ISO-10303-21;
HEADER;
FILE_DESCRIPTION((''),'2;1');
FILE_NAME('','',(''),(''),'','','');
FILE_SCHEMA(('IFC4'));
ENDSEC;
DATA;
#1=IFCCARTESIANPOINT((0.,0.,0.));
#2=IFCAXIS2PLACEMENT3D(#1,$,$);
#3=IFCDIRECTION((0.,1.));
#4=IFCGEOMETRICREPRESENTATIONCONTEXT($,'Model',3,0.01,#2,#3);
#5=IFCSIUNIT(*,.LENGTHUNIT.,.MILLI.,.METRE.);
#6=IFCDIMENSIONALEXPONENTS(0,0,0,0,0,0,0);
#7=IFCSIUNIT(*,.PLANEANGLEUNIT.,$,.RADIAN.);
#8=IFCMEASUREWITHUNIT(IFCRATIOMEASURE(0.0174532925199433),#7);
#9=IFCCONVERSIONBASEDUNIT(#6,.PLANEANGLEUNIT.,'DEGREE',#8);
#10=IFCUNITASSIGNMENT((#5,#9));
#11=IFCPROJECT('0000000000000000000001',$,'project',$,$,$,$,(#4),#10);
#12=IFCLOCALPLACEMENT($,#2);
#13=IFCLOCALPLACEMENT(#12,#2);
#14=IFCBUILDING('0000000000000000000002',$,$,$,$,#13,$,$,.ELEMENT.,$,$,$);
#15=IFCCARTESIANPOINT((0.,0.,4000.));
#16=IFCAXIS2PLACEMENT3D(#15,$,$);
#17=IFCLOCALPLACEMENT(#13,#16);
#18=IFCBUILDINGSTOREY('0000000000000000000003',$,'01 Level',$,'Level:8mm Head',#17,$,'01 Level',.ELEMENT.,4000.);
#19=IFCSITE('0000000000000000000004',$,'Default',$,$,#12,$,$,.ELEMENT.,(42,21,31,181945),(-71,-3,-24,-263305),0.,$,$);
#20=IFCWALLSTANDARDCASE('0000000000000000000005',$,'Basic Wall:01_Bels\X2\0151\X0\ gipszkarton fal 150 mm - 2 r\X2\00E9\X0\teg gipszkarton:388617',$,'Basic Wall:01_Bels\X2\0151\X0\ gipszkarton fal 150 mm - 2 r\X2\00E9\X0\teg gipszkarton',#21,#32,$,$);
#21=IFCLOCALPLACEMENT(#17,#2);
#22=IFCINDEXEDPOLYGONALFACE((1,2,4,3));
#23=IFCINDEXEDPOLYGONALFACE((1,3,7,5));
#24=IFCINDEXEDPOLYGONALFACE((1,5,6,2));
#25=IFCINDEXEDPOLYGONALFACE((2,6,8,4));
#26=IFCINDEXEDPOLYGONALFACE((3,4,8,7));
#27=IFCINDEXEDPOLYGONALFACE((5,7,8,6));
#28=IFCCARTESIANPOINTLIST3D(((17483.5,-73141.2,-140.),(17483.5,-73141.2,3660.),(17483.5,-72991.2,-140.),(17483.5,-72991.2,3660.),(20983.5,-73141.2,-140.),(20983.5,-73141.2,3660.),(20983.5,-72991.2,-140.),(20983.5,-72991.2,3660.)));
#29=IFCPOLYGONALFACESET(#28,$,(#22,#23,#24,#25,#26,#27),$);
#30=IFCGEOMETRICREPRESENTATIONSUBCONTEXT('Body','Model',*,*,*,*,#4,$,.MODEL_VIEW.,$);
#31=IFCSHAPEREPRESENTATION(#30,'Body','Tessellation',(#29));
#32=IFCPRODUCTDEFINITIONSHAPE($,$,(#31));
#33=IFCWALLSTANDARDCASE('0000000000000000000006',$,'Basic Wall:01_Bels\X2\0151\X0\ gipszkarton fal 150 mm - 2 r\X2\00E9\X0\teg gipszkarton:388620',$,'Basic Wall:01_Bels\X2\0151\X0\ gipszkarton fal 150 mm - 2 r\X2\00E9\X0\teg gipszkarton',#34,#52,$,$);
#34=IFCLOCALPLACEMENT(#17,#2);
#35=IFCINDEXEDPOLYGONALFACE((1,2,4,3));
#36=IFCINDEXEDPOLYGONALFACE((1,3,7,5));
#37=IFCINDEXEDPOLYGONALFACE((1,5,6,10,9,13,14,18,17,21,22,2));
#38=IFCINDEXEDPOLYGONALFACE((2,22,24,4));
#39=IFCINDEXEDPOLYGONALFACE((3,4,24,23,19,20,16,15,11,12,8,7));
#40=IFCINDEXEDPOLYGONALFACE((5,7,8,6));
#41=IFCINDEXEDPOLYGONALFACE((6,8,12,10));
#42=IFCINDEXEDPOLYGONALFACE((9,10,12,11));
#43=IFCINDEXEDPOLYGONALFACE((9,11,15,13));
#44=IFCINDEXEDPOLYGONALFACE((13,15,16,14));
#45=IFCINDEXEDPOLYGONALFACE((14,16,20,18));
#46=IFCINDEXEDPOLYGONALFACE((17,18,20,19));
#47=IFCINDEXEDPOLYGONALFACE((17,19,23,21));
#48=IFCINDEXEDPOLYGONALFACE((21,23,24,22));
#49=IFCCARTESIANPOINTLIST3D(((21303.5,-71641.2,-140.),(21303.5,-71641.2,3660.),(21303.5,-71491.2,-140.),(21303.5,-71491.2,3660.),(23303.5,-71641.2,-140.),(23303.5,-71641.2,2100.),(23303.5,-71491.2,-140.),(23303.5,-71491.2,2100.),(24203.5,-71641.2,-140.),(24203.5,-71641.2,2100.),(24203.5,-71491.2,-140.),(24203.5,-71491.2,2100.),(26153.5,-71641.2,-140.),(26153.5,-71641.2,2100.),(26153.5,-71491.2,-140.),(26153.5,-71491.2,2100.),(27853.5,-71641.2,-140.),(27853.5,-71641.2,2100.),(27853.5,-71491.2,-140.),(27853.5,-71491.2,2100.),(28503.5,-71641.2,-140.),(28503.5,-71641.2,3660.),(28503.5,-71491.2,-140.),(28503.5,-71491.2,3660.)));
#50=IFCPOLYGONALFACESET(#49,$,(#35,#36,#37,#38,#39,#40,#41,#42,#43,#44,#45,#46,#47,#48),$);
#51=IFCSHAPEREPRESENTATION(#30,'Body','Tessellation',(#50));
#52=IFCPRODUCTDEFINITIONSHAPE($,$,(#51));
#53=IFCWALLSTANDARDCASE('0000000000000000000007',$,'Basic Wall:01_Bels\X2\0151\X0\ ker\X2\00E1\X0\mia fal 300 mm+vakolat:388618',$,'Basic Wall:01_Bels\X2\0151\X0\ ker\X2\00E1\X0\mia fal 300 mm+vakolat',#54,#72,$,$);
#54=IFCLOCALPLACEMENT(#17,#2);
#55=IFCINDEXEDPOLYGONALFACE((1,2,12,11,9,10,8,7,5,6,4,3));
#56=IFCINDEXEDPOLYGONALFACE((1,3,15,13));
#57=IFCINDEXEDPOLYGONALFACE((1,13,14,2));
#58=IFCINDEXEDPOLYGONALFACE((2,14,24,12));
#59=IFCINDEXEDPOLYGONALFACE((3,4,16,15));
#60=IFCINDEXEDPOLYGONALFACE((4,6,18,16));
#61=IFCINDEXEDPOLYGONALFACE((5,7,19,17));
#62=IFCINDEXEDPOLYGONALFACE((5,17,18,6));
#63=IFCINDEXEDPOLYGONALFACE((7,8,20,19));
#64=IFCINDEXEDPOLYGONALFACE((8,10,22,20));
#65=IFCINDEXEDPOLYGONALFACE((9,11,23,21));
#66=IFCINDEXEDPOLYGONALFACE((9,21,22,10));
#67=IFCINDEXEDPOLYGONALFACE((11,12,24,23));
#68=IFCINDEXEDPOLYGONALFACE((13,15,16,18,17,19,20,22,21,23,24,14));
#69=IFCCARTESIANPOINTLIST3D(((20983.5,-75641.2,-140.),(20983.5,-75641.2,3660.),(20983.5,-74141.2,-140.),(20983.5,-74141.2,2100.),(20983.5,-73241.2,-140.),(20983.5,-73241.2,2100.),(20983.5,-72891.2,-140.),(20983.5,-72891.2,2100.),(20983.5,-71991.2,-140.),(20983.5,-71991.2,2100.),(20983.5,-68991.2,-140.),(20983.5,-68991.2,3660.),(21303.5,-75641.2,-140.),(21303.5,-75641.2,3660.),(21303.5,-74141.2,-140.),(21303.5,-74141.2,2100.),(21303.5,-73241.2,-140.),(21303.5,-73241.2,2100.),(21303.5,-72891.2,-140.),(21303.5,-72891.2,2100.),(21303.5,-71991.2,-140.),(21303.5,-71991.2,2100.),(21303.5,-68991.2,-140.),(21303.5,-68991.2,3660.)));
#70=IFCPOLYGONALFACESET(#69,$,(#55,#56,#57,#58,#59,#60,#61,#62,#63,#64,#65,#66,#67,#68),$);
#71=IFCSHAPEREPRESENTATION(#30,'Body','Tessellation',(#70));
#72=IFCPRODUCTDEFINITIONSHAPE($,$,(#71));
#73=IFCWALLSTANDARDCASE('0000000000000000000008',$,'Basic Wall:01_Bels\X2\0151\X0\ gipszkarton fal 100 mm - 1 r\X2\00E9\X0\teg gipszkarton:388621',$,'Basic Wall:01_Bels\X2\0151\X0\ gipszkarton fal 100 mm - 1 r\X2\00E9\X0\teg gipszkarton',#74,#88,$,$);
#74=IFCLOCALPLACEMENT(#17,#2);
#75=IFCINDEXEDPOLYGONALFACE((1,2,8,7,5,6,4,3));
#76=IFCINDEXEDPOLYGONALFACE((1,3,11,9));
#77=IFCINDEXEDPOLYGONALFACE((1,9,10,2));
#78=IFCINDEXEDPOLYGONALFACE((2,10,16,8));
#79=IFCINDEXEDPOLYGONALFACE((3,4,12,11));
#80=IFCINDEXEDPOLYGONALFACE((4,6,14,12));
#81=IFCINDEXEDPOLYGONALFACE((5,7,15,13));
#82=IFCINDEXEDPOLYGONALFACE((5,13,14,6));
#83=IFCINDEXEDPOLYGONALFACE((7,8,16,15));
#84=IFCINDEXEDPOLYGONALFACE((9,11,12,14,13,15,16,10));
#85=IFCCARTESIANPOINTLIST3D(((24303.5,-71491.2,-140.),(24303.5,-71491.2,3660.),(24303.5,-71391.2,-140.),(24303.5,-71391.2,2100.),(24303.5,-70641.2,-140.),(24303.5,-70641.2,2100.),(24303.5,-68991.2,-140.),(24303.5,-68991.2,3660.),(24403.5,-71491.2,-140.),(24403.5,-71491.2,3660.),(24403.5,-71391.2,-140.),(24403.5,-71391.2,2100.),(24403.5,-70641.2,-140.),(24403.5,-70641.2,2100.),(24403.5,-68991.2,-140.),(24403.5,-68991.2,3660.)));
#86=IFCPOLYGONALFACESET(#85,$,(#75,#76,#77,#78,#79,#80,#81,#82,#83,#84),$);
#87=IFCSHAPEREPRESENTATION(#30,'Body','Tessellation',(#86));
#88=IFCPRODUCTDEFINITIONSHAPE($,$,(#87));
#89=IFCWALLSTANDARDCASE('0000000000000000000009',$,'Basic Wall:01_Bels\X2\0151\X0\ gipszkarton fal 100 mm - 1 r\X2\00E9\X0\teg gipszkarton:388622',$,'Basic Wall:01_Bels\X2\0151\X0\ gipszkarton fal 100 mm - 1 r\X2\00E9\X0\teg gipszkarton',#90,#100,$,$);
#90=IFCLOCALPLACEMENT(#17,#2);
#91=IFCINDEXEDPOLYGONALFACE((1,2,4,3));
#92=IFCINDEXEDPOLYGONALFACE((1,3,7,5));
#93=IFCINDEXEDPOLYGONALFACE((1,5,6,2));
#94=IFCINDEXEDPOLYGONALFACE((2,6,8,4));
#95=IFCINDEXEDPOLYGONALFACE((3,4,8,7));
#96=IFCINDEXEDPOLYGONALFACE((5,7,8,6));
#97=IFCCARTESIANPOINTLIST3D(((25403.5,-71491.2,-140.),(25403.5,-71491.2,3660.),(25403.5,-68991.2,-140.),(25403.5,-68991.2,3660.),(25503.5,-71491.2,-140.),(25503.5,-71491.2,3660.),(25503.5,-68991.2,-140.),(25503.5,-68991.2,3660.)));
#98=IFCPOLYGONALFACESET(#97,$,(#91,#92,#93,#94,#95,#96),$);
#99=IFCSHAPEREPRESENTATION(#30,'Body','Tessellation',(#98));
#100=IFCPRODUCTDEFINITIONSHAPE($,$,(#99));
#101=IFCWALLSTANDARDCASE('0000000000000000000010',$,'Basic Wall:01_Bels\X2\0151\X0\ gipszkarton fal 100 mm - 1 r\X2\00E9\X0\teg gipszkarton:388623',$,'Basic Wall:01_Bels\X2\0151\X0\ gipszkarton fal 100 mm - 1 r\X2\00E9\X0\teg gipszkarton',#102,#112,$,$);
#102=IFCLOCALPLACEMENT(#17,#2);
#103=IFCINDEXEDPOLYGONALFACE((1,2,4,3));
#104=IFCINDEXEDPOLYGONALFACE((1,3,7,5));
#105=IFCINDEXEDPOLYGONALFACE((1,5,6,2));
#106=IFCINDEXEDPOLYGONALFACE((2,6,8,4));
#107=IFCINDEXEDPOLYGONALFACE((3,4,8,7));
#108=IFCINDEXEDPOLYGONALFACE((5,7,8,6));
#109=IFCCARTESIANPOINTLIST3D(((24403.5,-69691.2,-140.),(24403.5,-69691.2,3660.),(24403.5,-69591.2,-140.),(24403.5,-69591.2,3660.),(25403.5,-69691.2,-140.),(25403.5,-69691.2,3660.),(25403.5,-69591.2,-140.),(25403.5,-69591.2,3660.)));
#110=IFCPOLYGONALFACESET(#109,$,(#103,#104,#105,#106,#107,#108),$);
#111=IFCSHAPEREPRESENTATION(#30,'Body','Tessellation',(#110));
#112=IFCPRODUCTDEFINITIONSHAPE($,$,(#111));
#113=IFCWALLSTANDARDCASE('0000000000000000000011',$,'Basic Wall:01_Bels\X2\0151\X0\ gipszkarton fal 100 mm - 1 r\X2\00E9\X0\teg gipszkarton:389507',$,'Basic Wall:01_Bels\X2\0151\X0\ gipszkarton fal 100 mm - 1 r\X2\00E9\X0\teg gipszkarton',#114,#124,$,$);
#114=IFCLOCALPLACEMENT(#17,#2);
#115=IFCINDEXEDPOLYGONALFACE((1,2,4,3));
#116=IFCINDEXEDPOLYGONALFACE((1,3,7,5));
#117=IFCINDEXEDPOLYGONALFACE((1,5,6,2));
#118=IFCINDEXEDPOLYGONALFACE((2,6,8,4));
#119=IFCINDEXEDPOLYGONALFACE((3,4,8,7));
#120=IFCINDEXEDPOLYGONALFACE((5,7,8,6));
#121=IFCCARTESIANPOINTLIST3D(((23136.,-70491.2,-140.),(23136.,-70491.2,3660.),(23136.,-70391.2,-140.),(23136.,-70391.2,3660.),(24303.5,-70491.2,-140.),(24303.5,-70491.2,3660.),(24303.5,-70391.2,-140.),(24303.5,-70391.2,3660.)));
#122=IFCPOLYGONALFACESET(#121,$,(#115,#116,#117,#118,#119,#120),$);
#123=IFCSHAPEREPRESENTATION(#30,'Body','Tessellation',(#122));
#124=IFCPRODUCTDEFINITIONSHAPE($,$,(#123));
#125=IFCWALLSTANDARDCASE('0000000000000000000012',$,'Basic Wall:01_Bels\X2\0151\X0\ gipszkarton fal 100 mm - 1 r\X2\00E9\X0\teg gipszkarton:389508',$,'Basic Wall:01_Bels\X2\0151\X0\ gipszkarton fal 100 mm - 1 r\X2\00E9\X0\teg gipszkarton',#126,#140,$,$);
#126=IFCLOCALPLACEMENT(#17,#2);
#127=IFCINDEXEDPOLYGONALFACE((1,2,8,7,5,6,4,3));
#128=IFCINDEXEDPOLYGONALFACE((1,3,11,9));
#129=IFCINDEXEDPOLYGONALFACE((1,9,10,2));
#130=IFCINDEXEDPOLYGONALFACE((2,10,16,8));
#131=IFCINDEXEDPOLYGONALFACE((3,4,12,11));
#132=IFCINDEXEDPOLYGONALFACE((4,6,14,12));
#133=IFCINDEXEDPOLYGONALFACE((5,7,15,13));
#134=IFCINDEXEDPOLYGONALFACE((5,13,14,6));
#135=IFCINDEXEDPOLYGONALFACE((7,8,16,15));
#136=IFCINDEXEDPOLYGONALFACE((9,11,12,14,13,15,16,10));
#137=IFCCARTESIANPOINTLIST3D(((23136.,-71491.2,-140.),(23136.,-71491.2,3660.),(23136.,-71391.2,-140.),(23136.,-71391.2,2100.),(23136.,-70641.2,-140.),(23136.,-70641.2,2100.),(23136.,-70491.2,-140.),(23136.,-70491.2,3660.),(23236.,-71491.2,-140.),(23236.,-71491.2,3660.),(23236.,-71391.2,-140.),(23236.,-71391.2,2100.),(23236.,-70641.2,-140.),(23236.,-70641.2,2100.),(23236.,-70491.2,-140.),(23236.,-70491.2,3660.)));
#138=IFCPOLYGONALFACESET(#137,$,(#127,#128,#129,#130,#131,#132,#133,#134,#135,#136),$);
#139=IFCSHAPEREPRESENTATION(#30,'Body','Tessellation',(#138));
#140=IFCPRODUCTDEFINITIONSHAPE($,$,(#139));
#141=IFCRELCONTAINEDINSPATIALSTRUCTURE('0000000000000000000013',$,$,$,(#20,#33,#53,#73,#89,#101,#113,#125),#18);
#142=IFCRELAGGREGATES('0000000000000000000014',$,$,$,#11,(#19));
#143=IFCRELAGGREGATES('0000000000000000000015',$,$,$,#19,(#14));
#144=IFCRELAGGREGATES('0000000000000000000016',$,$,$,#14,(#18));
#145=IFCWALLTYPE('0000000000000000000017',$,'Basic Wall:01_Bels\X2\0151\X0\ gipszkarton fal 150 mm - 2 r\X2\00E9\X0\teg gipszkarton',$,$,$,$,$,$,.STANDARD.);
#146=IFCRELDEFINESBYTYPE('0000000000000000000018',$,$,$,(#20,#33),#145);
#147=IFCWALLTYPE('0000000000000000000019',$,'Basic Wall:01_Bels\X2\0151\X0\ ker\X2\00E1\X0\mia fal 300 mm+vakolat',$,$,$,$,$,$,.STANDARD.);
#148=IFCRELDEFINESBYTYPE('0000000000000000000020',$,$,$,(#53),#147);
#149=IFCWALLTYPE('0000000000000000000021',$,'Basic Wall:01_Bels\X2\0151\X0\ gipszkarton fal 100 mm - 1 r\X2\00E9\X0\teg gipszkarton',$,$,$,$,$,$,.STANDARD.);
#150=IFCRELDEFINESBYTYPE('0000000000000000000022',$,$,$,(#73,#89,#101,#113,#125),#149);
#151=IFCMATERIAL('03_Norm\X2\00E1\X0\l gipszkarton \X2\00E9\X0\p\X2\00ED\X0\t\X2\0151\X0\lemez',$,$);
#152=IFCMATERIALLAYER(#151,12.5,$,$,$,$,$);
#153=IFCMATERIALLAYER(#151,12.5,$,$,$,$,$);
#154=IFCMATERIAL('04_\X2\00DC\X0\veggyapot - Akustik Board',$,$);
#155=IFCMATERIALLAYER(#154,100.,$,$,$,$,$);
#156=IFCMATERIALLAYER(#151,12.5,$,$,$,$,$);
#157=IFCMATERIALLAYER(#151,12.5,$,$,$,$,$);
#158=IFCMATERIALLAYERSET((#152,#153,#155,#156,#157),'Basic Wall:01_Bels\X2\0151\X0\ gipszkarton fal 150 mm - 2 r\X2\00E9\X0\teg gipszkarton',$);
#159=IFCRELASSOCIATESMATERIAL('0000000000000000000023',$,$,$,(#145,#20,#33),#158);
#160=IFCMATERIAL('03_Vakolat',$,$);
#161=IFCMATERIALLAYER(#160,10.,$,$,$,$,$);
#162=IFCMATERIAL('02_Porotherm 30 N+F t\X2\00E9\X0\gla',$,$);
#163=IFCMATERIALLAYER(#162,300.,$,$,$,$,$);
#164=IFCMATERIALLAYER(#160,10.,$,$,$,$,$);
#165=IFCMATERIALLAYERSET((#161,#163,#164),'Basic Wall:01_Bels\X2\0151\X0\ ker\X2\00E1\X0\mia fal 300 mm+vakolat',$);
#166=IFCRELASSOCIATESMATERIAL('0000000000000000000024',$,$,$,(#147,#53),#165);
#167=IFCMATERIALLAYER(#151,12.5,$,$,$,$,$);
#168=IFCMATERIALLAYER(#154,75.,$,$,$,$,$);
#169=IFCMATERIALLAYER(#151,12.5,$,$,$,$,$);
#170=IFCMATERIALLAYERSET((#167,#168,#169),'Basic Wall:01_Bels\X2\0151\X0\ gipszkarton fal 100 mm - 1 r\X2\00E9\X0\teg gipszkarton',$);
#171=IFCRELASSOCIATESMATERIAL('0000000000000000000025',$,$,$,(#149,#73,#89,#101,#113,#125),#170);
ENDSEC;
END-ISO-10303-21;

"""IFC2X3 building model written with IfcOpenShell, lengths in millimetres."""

from ifc_helpers import new_model, entity, si_unit, converted_unit, direction, frame, frame_2d, origin, origin_2d_with_axis, place, context, subcontext, project, spatial, rectangle, extrude, material, layer, layer_set, layer_usage, type_object, element, save


model = new_model("IFC2X3")

# Units and contexts
model_context = context("Model", 3, precision=0.01, world=origin(), true_north=direction((0.0, 1.0)))
body_context = subcontext(model_context, "Body", "Model", "MODEL_VIEW")
ifc_project = project(units=[si_unit("LENGTHUNIT", "METRE", prefix="MILLI"), converted_unit("PLANEANGLEUNIT", "DEGREE", entity("IfcRatioMeasure", 0.0174532925199433), si_unit("PLANEANGLEUNIT", "RADIAN"), dimensions=[0, 0, 0, 0, 0, 0, 0])], contexts=[model_context])

# Site, building, storey
site_placement = place(None, origin())
site = spatial("IfcSite", under=ifc_project, at=site_placement, Name="Default", CompositionType="ELEMENT", RefLatitude=(42, 21, 31, 181945), RefLongitude=(-71, -3, -24, -263305), RefElevation=0.0)
building_placement = place(site_placement, origin())
building = spatial("IfcBuilding", under=site, at=building_placement, CompositionType="ELEMENT")
storey_placement = place(building_placement, frame((0.0, 0.0, 4000.0)))
storey = spatial("IfcBuildingStorey", under=building, at=storey_placement, Name="01 Level", ObjectType="Level:8mm Head", LongName="01 Level", CompositionType="ELEMENT", Elevation=4000.0)

# Wall
ifc_material_1 = material(Name="03_Normál gipszkarton építőlemez")
ifc_layer_1 = layer(ifc_material_1, 12.5)
ifc_layer_2 = layer(ifc_material_1, 12.5)
ifc_material_2 = material(Name="04_Üveggyapot - Akustik Board")
ifc_layer_3 = layer(ifc_material_2, 100.0)
ifc_layer_4 = layer(ifc_material_1, 12.5)
ifc_layer_5 = layer(ifc_material_1, 12.5)
ifc_layer_set_1 = layer_set([ifc_layer_1, ifc_layer_2, ifc_layer_3, ifc_layer_4, ifc_layer_5], Name="Basic Wall:01_Belső gipszkarton fal 150 mm - 2 réteg gipszkarton")
ifc_layer_usage_1 = layer_usage(ifc_layer_set_1, "AXIS2", "NEGATIVE", 75.0)
wall_type_1 = type_object("IfcWallType", Name="Basic Wall:01_Belső gipszkarton fal 150 mm - 2 réteg gipszkarton", PredefinedType="STANDARD", material=ifc_layer_set_1)
wall_1_placement = place(storey_placement, frame((17483.5, -73066.2, -140.0)))
element("IfcWallStandardCase", 1, at=wall_1_placement, inside=storey, type_object=wall_type_1, material=ifc_layer_usage_1, Name="Basic Wall:01_Belső gipszkarton fal 150 mm - 2 réteg gipszkarton:388617", ObjectType="Basic Wall:01_Belső gipszkarton fal 150 mm - 2 réteg gipszkarton", context=body_context, shape_type="SweptSolid", body=[
    extrude(rectangle(XDim=3500.0, YDim=150.0, at=frame_2d((1750.0, 0.0), x_axis=(-1.0, 0.0))), origin(), (0.0, 0.0, 1.0), 3800.0),
])

# Walls, openings
ifc_layer_usage_2 = layer_usage(ifc_layer_set_1, "AXIS2", "NEGATIVE", 75.0)
wall_2_placement = place(storey_placement, frame((21303.5, -71566.2, -140.0)))
wall_2 = element("IfcWallStandardCase", 2, at=wall_2_placement, inside=storey, type_object=wall_type_1, material=ifc_layer_usage_2, Name="Basic Wall:01_Belső gipszkarton fal 150 mm - 2 réteg gipszkarton:388620", ObjectType="Basic Wall:01_Belső gipszkarton fal 150 mm - 2 réteg gipszkarton", context=body_context, shape_type="SweptSolid", body=[
    extrude(rectangle(XDim=7200.0, YDim=150.0, at=frame_2d((3600.0, 0.0), x_axis=(-1.0, 0.0))), origin(), (0.0, 0.0, 1.0), 3800.0),
])
opening_1_placement = place(wall_2_placement, frame((4850.0, -75.0, 0.0)))
element("IfcOpeningElement", 3, at=opening_1_placement, cuts=wall_2, ObjectType="Opening", context=body_context, shape_type="SweptSolid", body=[
    extrude(rectangle(XDim=2240.0, YDim=1700.0, at=frame_2d((0.0, 0.0), x_axis=(1.0, 0.0))), frame((850.0, 0.0, 1120.0), z_axis=(0.0, 1.0, 0.0), x_axis=(0.0, 0.0, -1.0)), (0.0, 0.0, 1.0), 150.0),
])
opening_2_placement = place(wall_2_placement, frame((2000.0, -1449.0, 0.0)))
element("IfcOpeningElement", 4, at=opening_2_placement, cuts=wall_2, ObjectType="Opening", context=body_context, shape_type="SweptSolid", body=[
    extrude(rectangle(XDim=2240.0, YDim=900.0, at=frame_2d((0.0, 0.0), x_axis=(0.0, 1.0))), frame((450.0, 0.0, 1120.0), z_axis=(0.0, 1.0, 0.0), x_axis=(-1.0, 0.0, 0.0)), (0.0, 0.0, 1.0), 3048.0),
])
ifc_material_3 = material(Name="03_Vakolat")
ifc_layer_6 = layer(ifc_material_3, 10.0)
ifc_material_4 = material(Name="02_Porotherm 30 N+F tégla")
ifc_layer_7 = layer(ifc_material_4, 300.0)
ifc_layer_8 = layer(ifc_material_3, 10.0)
ifc_layer_set_2 = layer_set([ifc_layer_6, ifc_layer_7, ifc_layer_8], Name="Basic Wall:01_Belső kerámia fal 300 mm+vakolat")
ifc_layer_usage_3 = layer_usage(ifc_layer_set_2, "AXIS2", "NEGATIVE", 160.0)
wall_type_2 = type_object("IfcWallType", Name="Basic Wall:01_Belső kerámia fal 300 mm+vakolat", PredefinedType="STANDARD", material=ifc_layer_set_2)
wall_3_placement = place(storey_placement, frame((21143.5, -68991.2, -140.0), z_axis=(0.0, 0.0, 1.0), x_axis=(0.0, -1.0, 0.0)))
wall_3 = element("IfcWallStandardCase", 5, at=wall_3_placement, inside=storey, type_object=wall_type_2, material=ifc_layer_usage_3, Name="Basic Wall:01_Belső kerámia fal 300 mm+vakolat:388618", ObjectType="Basic Wall:01_Belső kerámia fal 300 mm+vakolat", context=body_context, shape_type="SweptSolid", body=[
    extrude(rectangle(XDim=6650.0, YDim=320.0, at=frame_2d((3325.0, 0.0), x_axis=(-1.0, 0.0))), origin(), (0.0, 0.0, 1.0), 3800.0),
])
opening_3_placement = place(wall_3_placement, frame((3900.0, -1364.0, 0.0), z_axis=(0.0, 0.0, 1.0), x_axis=(0.0, 1.0, 0.0)))
element("IfcOpeningElement", 6, at=opening_3_placement, cuts=wall_3, ObjectType="Opening", context=body_context, shape_type="SweptSolid", body=[
    extrude(rectangle(XDim=2240.0, YDim=900.0, at=origin_2d_with_axis()), frame((0.0, 450.0, 1120.0), z_axis=(1.0, 0.0, 0.0), x_axis=(0.0, 0.0, 1.0)), (0.0, 0.0, 1.0), 3048.0),
])
opening_4_placement = place(wall_3_placement, frame((5150.0, -1364.0, 0.0), z_axis=(0.0, 0.0, 1.0), x_axis=(0.0, 1.0, 0.0)))
element("IfcOpeningElement", 7, at=opening_4_placement, cuts=wall_3, ObjectType="Opening", context=body_context, shape_type="SweptSolid", body=[
    extrude(rectangle(XDim=2240.0, YDim=900.0, at=frame_2d((0.0, 0.0), x_axis=(0.0, 1.0))), frame((0.0, 450.0, 1120.0), z_axis=(1.0, 0.0, 0.0), x_axis=(0.0, 1.0, 0.0)), (0.0, 0.0, 1.0), 3048.0),
])

# Wall, opening
ifc_layer_9 = layer(ifc_material_1, 12.5)
ifc_layer_10 = layer(ifc_material_2, 75.0)
ifc_layer_11 = layer(ifc_material_1, 12.5)
ifc_layer_set_3 = layer_set([ifc_layer_9, ifc_layer_10, ifc_layer_11], Name="Basic Wall:01_Belső gipszkarton fal 100 mm - 1 réteg gipszkarton")
ifc_layer_usage_4 = layer_usage(ifc_layer_set_3, "AXIS2", "NEGATIVE", 50.0)
wall_type_3 = type_object("IfcWallType", Name="Basic Wall:01_Belső gipszkarton fal 100 mm - 1 réteg gipszkarton", PredefinedType="STANDARD", material=ifc_layer_set_3)
wall_4_placement = place(storey_placement, frame((24353.5, -71491.2, -140.0), z_axis=(0.0, 0.0, 1.0), x_axis=(0.0, 1.0, 0.0)))
wall_4 = element("IfcWallStandardCase", 8, at=wall_4_placement, inside=storey, type_object=wall_type_3, material=ifc_layer_usage_4, Name="Basic Wall:01_Belső gipszkarton fal 100 mm - 1 réteg gipszkarton:388621", ObjectType="Basic Wall:01_Belső gipszkarton fal 100 mm - 1 réteg gipszkarton", context=body_context, shape_type="SweptSolid", body=[
    extrude(rectangle(XDim=2500.0, YDim=100.0, at=frame_2d((1250.0, 0.0), x_axis=(-1.0, 0.0))), origin(), (0.0, 0.0, 1.0), 3800.0),
])
opening_5_placement = place(wall_4_placement, frame((100.0, 1574.0, 0.0), z_axis=(0.0, 0.0, 1.0), x_axis=(0.0, -1.0, 0.0)))
element("IfcOpeningElement", 9, at=opening_5_placement, cuts=wall_4, ObjectType="Opening", context=body_context, shape_type="SweptSolid", body=[
    extrude(rectangle(XDim=2240.0, YDim=750.0, at=frame_2d((0.0, 0.0), x_axis=(0.0, 1.0))), frame((3048.0, 375.0, 1120.0), z_axis=(-1.0, 0.0, 0.0), x_axis=(0.0, -1.0, 0.0)), (0.0, 0.0, 1.0), 3048.0),
])

# Walls
ifc_layer_usage_5 = layer_usage(ifc_layer_set_3, "AXIS2", "NEGATIVE", 50.0)
wall_5_placement = place(storey_placement, frame((25453.5, -71491.2, -140.0), z_axis=(0.0, 0.0, 1.0), x_axis=(0.0, 1.0, 0.0)))
element("IfcWallStandardCase", 10, at=wall_5_placement, inside=storey, type_object=wall_type_3, material=ifc_layer_usage_5, Name="Basic Wall:01_Belső gipszkarton fal 100 mm - 1 réteg gipszkarton:388622", ObjectType="Basic Wall:01_Belső gipszkarton fal 100 mm - 1 réteg gipszkarton", context=body_context, shape_type="SweptSolid", body=[
    extrude(rectangle(XDim=2500.0, YDim=100.0, at=frame_2d((1250.0, 0.0), x_axis=(-1.0, 0.0))), origin(), (0.0, 0.0, 1.0), 3800.0),
])
ifc_layer_usage_6 = layer_usage(ifc_layer_set_3, "AXIS2", "NEGATIVE", 50.0)
wall_6_placement = place(storey_placement, frame((24403.5, -69641.2, -140.0)))
element("IfcWallStandardCase", 11, at=wall_6_placement, inside=storey, type_object=wall_type_3, material=ifc_layer_usage_6, Name="Basic Wall:01_Belső gipszkarton fal 100 mm - 1 réteg gipszkarton:388623", ObjectType="Basic Wall:01_Belső gipszkarton fal 100 mm - 1 réteg gipszkarton", context=body_context, shape_type="SweptSolid", body=[
    extrude(rectangle(XDim=1000.0, YDim=100.0, at=frame_2d((500.0, 0.0), x_axis=(-1.0, 0.0))), origin(), (0.0, 0.0, 1.0), 3800.0),
])
ifc_layer_usage_7 = layer_usage(ifc_layer_set_3, "AXIS2", "NEGATIVE", 50.0)
wall_7_placement = place(storey_placement, frame((24303.5, -70441.2, -140.0), z_axis=(0.0, 0.0, 1.0), x_axis=(-1.0, 0.0, 0.0)))
element("IfcWallStandardCase", 12, at=wall_7_placement, inside=storey, type_object=wall_type_3, material=ifc_layer_usage_7, Name="Basic Wall:01_Belső gipszkarton fal 100 mm - 1 réteg gipszkarton:389507", ObjectType="Basic Wall:01_Belső gipszkarton fal 100 mm - 1 réteg gipszkarton", context=body_context, shape_type="SweptSolid", body=[
    extrude(rectangle(XDim=1167.5, YDim=100.0, at=frame_2d((583.7, 0.0), x_axis=(-1.0, 0.0))), origin(), (0.0, 0.0, 1.0), 3800.0),
])

# Wall, opening
ifc_layer_usage_8 = layer_usage(ifc_layer_set_3, "AXIS2", "NEGATIVE", 50.0)
wall_8_placement = place(storey_placement, frame((23186.0, -70491.2, -140.0), z_axis=(0.0, 0.0, 1.0), x_axis=(0.0, -1.0, 0.0)))
wall_8 = element("IfcWallStandardCase", 13, at=wall_8_placement, inside=storey, type_object=wall_type_3, material=ifc_layer_usage_8, Name="Basic Wall:01_Belső gipszkarton fal 100 mm - 1 réteg gipszkarton:389508", ObjectType="Basic Wall:01_Belső gipszkarton fal 100 mm - 1 réteg gipszkarton", context=body_context, shape_type="SweptSolid", body=[
    extrude(rectangle(XDim=1000.0, YDim=100.0, at=frame_2d((500.0, 0.0), x_axis=(-1.0, 0.0))), origin(), (0.0, 0.0, 1.0), 3800.0),
])
opening_6_placement = place(wall_8_placement, frame((900.0, -1474.0, 0.0), z_axis=(0.0, 0.0, 1.0), x_axis=(0.0, 1.0, 0.0)))
element("IfcOpeningElement", 14, at=opening_6_placement, cuts=wall_8, ObjectType="Opening", context=body_context, shape_type="SweptSolid", body=[
    extrude(rectangle(XDim=2240.0, YDim=750.0, at=origin_2d_with_axis()), frame((0.0, 375.0, 1120.0), z_axis=(1.0, 0.0, 0.0), x_axis=(0.0, 0.0, 1.0)), (0.0, 0.0, 1.0), 3048.0),
])

save(model, "model.ifc")
